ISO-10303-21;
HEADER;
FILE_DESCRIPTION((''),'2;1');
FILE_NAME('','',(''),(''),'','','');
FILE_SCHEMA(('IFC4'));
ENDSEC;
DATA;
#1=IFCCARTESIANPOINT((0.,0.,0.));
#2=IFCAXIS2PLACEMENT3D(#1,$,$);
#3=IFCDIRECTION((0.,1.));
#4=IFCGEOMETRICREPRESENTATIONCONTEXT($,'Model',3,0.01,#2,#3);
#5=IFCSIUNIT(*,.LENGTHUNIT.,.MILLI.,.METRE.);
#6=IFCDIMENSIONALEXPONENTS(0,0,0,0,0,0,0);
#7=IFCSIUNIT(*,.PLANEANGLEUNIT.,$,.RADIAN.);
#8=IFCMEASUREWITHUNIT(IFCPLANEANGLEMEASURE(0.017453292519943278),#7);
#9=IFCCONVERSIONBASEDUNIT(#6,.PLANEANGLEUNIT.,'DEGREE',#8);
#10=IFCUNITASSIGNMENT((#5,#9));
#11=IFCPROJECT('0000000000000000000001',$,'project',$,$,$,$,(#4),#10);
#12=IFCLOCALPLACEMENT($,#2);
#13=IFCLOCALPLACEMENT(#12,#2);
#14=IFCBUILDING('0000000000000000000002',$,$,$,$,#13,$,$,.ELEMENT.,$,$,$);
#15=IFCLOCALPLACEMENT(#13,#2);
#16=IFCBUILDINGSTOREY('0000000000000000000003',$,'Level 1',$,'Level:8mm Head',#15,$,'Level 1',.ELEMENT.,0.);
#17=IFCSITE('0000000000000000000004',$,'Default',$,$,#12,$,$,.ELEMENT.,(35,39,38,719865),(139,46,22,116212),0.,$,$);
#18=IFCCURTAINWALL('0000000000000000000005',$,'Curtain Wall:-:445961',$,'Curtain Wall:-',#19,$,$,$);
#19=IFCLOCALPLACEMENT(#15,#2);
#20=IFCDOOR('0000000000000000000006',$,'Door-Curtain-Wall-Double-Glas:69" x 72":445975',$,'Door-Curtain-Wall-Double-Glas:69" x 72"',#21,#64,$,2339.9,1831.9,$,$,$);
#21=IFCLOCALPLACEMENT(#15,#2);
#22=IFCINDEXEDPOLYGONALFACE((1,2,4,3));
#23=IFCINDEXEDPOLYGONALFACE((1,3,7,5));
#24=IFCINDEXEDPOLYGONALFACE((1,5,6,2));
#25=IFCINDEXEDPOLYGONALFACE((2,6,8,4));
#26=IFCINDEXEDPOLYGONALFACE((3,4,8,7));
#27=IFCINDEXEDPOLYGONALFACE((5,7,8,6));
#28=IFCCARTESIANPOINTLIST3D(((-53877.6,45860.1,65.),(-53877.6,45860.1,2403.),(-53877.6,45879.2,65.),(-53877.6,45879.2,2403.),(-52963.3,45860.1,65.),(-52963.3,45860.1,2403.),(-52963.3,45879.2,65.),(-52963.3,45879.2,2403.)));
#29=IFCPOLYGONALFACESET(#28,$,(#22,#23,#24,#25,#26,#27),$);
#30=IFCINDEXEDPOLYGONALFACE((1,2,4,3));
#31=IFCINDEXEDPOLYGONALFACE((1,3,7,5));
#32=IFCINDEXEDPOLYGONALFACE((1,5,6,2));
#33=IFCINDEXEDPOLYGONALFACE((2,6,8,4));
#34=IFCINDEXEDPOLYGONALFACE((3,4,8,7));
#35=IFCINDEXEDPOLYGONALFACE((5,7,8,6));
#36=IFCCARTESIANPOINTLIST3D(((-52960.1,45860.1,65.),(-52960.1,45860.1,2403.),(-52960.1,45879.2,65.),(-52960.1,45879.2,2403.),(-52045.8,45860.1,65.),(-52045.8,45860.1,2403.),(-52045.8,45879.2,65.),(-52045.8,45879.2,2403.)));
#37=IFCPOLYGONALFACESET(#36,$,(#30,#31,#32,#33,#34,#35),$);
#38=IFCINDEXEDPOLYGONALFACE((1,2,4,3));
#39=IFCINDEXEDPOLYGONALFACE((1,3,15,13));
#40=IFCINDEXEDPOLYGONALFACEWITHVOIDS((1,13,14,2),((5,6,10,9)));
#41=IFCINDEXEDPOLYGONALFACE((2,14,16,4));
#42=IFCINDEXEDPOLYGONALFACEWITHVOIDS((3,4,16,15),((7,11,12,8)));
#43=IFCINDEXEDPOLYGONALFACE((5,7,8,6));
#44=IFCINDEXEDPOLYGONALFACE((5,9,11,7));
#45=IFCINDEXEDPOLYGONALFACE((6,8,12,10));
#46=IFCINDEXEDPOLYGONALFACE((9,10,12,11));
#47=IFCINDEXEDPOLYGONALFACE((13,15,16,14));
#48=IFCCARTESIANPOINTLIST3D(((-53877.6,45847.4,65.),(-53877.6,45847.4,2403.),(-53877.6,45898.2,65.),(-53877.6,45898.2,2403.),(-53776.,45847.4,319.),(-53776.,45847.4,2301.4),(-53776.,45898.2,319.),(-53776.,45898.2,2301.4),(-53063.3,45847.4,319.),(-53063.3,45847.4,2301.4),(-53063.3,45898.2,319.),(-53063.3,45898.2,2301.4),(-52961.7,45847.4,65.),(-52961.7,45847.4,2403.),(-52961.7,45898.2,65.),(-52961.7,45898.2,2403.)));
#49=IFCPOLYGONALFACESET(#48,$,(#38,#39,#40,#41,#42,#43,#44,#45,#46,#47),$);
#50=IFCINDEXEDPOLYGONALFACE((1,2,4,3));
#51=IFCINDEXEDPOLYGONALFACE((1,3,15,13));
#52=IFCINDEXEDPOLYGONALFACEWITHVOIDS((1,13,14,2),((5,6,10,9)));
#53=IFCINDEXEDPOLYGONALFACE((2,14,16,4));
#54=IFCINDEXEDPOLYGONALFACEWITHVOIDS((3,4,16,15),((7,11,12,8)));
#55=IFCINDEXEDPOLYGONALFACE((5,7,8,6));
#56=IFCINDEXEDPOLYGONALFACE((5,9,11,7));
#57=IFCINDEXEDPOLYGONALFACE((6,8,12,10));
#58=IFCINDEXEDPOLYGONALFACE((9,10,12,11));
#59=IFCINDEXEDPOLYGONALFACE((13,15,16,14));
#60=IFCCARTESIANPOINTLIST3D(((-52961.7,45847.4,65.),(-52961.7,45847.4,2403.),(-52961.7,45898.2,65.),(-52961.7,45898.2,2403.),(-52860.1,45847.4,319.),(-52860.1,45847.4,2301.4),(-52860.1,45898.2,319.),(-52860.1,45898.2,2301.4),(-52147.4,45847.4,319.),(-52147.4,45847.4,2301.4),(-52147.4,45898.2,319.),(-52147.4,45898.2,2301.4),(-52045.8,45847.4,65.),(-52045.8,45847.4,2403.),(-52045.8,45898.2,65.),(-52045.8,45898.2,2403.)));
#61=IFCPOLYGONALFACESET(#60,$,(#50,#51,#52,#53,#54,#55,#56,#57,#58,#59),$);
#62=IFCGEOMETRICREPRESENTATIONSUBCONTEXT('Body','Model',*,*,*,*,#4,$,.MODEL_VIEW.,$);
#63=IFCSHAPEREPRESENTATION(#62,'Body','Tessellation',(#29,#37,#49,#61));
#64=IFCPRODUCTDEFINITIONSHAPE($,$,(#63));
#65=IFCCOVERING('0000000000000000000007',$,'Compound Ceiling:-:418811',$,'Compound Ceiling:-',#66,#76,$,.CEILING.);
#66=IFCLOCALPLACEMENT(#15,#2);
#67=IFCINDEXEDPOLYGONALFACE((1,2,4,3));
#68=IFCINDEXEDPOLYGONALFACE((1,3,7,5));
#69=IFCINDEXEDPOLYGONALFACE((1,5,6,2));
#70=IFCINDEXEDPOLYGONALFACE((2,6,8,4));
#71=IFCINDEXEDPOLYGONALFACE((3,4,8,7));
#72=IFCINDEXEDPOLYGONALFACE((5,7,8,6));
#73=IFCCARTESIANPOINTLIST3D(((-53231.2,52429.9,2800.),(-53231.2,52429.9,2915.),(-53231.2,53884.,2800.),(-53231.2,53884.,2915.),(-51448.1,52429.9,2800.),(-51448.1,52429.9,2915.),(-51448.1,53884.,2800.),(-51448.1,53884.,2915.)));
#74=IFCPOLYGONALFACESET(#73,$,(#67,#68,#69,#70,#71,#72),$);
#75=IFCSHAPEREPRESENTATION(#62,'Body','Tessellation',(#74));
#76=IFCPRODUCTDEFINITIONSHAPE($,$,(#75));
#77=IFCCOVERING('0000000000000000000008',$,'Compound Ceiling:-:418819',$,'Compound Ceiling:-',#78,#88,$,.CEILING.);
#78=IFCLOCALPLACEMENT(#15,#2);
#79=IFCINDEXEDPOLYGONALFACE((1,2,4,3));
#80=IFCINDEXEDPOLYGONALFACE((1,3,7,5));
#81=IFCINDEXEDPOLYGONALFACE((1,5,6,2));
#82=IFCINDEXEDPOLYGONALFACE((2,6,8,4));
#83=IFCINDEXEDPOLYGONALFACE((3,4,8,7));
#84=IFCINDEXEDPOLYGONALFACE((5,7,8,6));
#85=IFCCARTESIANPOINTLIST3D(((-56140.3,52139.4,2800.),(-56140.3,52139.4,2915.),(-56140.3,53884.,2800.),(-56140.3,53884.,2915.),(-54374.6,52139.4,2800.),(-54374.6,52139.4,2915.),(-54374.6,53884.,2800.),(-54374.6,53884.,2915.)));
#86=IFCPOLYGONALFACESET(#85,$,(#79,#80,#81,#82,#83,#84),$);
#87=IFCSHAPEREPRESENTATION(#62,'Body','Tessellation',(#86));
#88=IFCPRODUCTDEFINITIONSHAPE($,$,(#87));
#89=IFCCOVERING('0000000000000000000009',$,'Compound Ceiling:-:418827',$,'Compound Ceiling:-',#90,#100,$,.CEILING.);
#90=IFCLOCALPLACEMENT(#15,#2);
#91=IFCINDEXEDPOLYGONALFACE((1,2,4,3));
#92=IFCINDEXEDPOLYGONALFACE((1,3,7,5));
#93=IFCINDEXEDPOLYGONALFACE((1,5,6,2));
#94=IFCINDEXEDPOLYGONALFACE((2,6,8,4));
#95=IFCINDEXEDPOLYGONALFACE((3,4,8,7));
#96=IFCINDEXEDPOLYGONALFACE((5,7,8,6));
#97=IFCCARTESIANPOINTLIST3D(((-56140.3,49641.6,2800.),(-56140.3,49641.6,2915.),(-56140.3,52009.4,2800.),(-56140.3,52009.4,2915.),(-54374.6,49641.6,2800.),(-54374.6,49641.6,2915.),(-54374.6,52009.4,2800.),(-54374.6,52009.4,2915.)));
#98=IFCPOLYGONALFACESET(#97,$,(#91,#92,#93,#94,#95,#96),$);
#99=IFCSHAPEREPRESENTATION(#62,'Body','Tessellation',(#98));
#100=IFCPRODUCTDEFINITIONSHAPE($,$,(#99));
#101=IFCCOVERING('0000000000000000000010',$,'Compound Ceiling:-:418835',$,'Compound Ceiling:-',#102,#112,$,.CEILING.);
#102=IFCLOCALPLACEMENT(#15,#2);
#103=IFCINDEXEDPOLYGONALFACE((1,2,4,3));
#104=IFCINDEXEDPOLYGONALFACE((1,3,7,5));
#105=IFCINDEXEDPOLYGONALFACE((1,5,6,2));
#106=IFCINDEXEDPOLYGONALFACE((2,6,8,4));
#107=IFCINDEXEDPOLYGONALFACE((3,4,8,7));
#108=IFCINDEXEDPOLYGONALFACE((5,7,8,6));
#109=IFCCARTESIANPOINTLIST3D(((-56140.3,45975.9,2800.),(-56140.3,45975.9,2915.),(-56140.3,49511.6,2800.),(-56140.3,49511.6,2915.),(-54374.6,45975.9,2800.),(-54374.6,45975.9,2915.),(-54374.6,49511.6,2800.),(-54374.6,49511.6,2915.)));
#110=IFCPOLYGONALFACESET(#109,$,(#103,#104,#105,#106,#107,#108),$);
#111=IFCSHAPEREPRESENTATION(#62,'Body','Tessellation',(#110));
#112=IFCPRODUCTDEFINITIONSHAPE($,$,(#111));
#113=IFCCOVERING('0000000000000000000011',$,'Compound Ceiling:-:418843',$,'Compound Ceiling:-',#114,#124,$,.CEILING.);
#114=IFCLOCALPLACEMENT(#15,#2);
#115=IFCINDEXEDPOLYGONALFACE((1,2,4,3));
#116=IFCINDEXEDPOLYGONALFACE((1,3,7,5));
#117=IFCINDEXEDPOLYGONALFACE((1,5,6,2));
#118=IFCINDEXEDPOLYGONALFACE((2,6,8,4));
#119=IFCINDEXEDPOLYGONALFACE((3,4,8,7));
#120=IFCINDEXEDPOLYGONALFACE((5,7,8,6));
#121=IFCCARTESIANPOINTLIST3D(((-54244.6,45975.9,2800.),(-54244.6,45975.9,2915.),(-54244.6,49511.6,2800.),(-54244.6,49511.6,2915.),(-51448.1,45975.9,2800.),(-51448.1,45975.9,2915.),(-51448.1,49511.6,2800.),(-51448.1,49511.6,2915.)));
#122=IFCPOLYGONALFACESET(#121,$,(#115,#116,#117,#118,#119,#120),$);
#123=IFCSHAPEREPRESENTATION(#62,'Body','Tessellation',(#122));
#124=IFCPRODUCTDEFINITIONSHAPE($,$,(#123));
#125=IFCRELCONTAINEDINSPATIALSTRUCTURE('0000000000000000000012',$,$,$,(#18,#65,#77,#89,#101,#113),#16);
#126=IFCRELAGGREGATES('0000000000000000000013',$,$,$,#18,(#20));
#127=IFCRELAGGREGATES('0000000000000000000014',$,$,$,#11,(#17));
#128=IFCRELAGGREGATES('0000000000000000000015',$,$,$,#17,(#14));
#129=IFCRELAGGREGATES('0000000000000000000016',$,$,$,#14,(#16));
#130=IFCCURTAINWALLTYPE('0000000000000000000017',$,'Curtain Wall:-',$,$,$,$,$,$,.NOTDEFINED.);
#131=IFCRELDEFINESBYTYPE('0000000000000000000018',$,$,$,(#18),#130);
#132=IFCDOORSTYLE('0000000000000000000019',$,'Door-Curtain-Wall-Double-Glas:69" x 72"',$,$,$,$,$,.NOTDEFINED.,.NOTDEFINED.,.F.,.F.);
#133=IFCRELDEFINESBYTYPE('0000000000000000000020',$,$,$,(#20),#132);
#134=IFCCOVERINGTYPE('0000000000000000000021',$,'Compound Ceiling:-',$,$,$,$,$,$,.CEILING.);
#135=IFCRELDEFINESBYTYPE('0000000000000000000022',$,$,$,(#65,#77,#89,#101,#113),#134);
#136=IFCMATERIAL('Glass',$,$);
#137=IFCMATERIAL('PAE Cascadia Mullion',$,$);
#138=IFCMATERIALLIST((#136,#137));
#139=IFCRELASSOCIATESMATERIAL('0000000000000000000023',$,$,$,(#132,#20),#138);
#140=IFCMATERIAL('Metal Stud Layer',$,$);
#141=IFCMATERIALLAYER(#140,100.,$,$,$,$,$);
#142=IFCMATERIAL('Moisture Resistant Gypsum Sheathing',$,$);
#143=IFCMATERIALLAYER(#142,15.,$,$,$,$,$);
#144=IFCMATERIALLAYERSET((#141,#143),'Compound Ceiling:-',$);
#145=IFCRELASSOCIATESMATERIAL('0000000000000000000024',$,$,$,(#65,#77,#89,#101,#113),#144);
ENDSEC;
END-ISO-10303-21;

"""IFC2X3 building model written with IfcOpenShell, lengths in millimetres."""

from ifc_helpers import new_model, entity, si_unit, converted_unit, direction, frame, frame_2d, origin, place, context, subcontext, project, spatial, polyline, rectangle, outline, extrude, source, transform, mapped, material, material_list, layer, layer_set, layer_usage, type_object, type_shapes, element, aggregate, save


model = new_model("IFC2X3")

# Units and contexts
model_context = context("Model", 3, precision=0.01, world=origin(), true_north=direction((0.0, 1.0)))
body_context = subcontext(model_context, "Body", "Model", "MODEL_VIEW")
ifc_project = project(units=[si_unit("LENGTHUNIT", "METRE", prefix="MILLI"), converted_unit("PLANEANGLEUNIT", "DEGREE", entity("IfcPlaneAngleMeasure", 0.017453292519943278), si_unit("PLANEANGLEUNIT", "RADIAN"), dimensions=[0, 0, 0, 0, 0, 0, 0])], contexts=[model_context])

# Site, building, storey
site_placement = place(None, origin())
site = spatial("IfcSite", under=ifc_project, at=site_placement, Name="Default", CompositionType="ELEMENT", RefLatitude=(35, 39, 38, 719865), RefLongitude=(139, 46, 22, 116212), RefElevation=0.0)
building_placement = place(site_placement, origin())
building = spatial("IfcBuilding", under=site, at=building_placement, CompositionType="ELEMENT")
storey_placement = place(building_placement, origin())
storey = spatial("IfcBuildingStorey", under=building, at=storey_placement, Name="Level 1", ObjectType="Level:8mm Head", LongName="Level 1", CompositionType="ELEMENT", Elevation=0.0)

# Curtain wall
curtain_wall_type = type_object("IfcCurtainWallType", Name="Curtain Wall:-", PredefinedType="NOTDEFINED")
curtain_wall_placement = place(storey_placement, origin())
curtain_wall = element("IfcCurtainWall", 1, at=curtain_wall_placement, inside=storey, type_object=curtain_wall_type, Name="Curtain Wall:-:445961", ObjectType="Curtain Wall:-")

# Shared definitions
ifc_material_1 = material(Name="Glass")

# Shared definitions
ifc_material_2 = material(Name="Metal Stud Layer")

# Door
ifc_material_3 = material(Name="PAE Cascadia Mullion")
ifc_material_list_1 = material_list([ifc_material_1, ifc_material_3])
door_style_1 = type_object("IfcDoorStyle", Name="Door-Curtain-Wall-Double-Glas:69\" x 72\"", ConstructionType="NOTDEFINED", OperationType="NOTDEFINED", ParameterTakesPrecedence=False, Sizeable=False, material=ifc_material_list_1)
shared_shape_1 = source(origin(), body_context, "Body", "SweptSolid", [
    extrude(rectangle(XDim=19.1, YDim=914.4, at=frame_2d((0.0, 0.0), x_axis=(1.0, 0.0))), frame((458.7, 41.3, 0.0), z_axis=(0.0, 0.0, 1.0), x_axis=(0.0, 1.0, 0.0)), (0.0, 0.0, 1.0), 2338.0),
    extrude(rectangle(XDim=19.1, YDim=914.3, at=frame_2d((0.0, 0.0), x_axis=(1.0, 0.0))), frame((-458.8, 41.3, 0.0), z_axis=(0.0, 0.0, 1.0), x_axis=(0.0, 1.0, 0.0)), (0.0, 0.0, 1.0), 2338.0),
    extrude(outline(polyline([(-458.0, -1169.0), (458.0, -1169.0), (458.0, 1169.0), (-458.0, 1169.0), (-458.0, -1169.0)]), holes=[polyline([(-356.4, -1067.4), (-356.4, 915.0), (356.4, 915.0), (356.4, -1067.4), (-356.4, -1067.4)])]), frame((458.0, 12.7, 1169.0), z_axis=(0.0, 1.0, 0.0), x_axis=(1.0, 0.0, 0.0)), (0.0, 0.0, 1.0), 50.8),
    extrude(outline(polyline([(-1169.0, -458.0), (1169.0, -458.0), (1169.0, 458.0), (-1169.0, 458.0), (-1169.0, -458.0)]), holes=[polyline([(-1067.4, -356.4), (-1067.4, 356.4), (915.0, 356.4), (915.0, -356.4), (-1067.4, -356.4)])]), frame((-458.0, 12.7, 1169.0), z_axis=(0.0, 1.0, 0.0), x_axis=(0.0, 0.0, -1.0)), (0.0, 0.0, 1.0), 50.8),
])
type_shapes(door_style_1, [shared_shape_1])
door_1_placement = place(curtain_wall_placement, frame((-52961.7, 45910.9, 65.0), z_axis=(0.0, 0.0, 1.0), x_axis=(-1.0, 0.0, 0.0)))
door_1 = element("IfcDoor", 2, at=door_1_placement, type_object=door_style_1, material=ifc_material_list_1, Name="Door-Curtain-Wall-Double-Glas:69\" x 72\":445975", ObjectType="Door-Curtain-Wall-Double-Glas:69\" x 72\"", OverallHeight=2339.9, OverallWidth=1831.9, context=body_context, shape_type="MappedRepresentation", body=[
    mapped(shared_shape_1, transform((0.0, 0.0, 0.0), scale=1.0)),
])
aggregate(curtain_wall, [door_1])

# Coverings
ifc_layer_1 = layer(ifc_material_2, 100.0)
ifc_material_4 = material(Name="Moisture Resistant Gypsum Sheathing")
ifc_layer_2 = layer(ifc_material_4, 15.0)
ifc_layer_set_1 = layer_set([ifc_layer_1, ifc_layer_2], Name="Compound Ceiling:-")
covering_type = type_object("IfcCoveringType", Name="Compound Ceiling:-", PredefinedType="CEILING")
ifc_layer_usage_1 = layer_usage(ifc_layer_set_1, "AXIS3", "NEGATIVE", 115.0)
covering_1_placement = place(storey_placement, origin())
element("IfcCovering", 3, at=covering_1_placement, inside=storey, type_object=covering_type, material=ifc_layer_usage_1, Name="Compound Ceiling:-:418811", ObjectType="Compound Ceiling:-", PredefinedType="CEILING", context=body_context, shape_type="SweptSolid", body=[
    extrude(rectangle(XDim=1783.1, YDim=1454.2, at=frame_2d((0.0, 0.0), x_axis=(1.0, 0.0))), frame((-52339.7, 53157.0, 2800.0)), (0.0, 0.0, 1.0), 115.0),
])
ifc_layer_usage_2 = layer_usage(ifc_layer_set_1, "AXIS3", "NEGATIVE", 115.0)
covering_2_placement = place(storey_placement, origin())
element("IfcCovering", 4, at=covering_2_placement, inside=storey, type_object=covering_type, material=ifc_layer_usage_2, Name="Compound Ceiling:-:418819", ObjectType="Compound Ceiling:-", PredefinedType="CEILING", context=body_context, shape_type="SweptSolid", body=[
    extrude(rectangle(XDim=1744.7, YDim=1765.7, at=frame_2d((0.0, 0.0), x_axis=(1.0, 0.0))), frame((-55257.4, 53011.7, 2800.0), z_axis=(0.0, 0.0, 1.0), x_axis=(0.0, 1.0, 0.0)), (0.0, 0.0, 1.0), 115.0),
])
ifc_layer_usage_3 = layer_usage(ifc_layer_set_1, "AXIS3", "NEGATIVE", 115.0)
covering_3_placement = place(storey_placement, origin())
element("IfcCovering", 5, at=covering_3_placement, inside=storey, type_object=covering_type, material=ifc_layer_usage_3, Name="Compound Ceiling:-:418827", ObjectType="Compound Ceiling:-", PredefinedType="CEILING", context=body_context, shape_type="SweptSolid", body=[
    extrude(rectangle(XDim=2367.8, YDim=1765.7, at=frame_2d((0.0, 0.0), x_axis=(1.0, 0.0))), frame((-55257.4, 50825.5, 2800.0), z_axis=(0.0, 0.0, 1.0), x_axis=(0.0, 1.0, 0.0)), (0.0, 0.0, 1.0), 115.0),
])
ifc_layer_usage_4 = layer_usage(ifc_layer_set_1, "AXIS3", "NEGATIVE", 115.0)
covering_4_placement = place(storey_placement, origin())
element("IfcCovering", 6, at=covering_4_placement, inside=storey, type_object=covering_type, material=ifc_layer_usage_4, Name="Compound Ceiling:-:418835", ObjectType="Compound Ceiling:-", PredefinedType="CEILING", context=body_context, shape_type="SweptSolid", body=[
    extrude(rectangle(XDim=3535.6, YDim=1765.7, at=frame_2d((0.0, 0.0), x_axis=(1.0, 0.0))), frame((-55257.4, 47743.7, 2800.0), z_axis=(0.0, 0.0, 1.0), x_axis=(0.0, -1.0, 0.0)), (0.0, 0.0, 1.0), 115.0),
])
ifc_layer_usage_5 = layer_usage(ifc_layer_set_1, "AXIS3", "NEGATIVE", 115.0)
covering_5_placement = place(storey_placement, origin())
element("IfcCovering", 7, at=covering_5_placement, inside=storey, type_object=covering_type, material=ifc_layer_usage_5, Name="Compound Ceiling:-:418843", ObjectType="Compound Ceiling:-", PredefinedType="CEILING", context=body_context, shape_type="SweptSolid", body=[
    extrude(rectangle(XDim=2796.4, YDim=3535.6, at=frame_2d((0.0, 0.0), x_axis=(1.0, 0.0))), frame((-52846.3, 47743.7, 2800.0)), (0.0, 0.0, 1.0), 115.0),
])

save(model, "model.ifc")
